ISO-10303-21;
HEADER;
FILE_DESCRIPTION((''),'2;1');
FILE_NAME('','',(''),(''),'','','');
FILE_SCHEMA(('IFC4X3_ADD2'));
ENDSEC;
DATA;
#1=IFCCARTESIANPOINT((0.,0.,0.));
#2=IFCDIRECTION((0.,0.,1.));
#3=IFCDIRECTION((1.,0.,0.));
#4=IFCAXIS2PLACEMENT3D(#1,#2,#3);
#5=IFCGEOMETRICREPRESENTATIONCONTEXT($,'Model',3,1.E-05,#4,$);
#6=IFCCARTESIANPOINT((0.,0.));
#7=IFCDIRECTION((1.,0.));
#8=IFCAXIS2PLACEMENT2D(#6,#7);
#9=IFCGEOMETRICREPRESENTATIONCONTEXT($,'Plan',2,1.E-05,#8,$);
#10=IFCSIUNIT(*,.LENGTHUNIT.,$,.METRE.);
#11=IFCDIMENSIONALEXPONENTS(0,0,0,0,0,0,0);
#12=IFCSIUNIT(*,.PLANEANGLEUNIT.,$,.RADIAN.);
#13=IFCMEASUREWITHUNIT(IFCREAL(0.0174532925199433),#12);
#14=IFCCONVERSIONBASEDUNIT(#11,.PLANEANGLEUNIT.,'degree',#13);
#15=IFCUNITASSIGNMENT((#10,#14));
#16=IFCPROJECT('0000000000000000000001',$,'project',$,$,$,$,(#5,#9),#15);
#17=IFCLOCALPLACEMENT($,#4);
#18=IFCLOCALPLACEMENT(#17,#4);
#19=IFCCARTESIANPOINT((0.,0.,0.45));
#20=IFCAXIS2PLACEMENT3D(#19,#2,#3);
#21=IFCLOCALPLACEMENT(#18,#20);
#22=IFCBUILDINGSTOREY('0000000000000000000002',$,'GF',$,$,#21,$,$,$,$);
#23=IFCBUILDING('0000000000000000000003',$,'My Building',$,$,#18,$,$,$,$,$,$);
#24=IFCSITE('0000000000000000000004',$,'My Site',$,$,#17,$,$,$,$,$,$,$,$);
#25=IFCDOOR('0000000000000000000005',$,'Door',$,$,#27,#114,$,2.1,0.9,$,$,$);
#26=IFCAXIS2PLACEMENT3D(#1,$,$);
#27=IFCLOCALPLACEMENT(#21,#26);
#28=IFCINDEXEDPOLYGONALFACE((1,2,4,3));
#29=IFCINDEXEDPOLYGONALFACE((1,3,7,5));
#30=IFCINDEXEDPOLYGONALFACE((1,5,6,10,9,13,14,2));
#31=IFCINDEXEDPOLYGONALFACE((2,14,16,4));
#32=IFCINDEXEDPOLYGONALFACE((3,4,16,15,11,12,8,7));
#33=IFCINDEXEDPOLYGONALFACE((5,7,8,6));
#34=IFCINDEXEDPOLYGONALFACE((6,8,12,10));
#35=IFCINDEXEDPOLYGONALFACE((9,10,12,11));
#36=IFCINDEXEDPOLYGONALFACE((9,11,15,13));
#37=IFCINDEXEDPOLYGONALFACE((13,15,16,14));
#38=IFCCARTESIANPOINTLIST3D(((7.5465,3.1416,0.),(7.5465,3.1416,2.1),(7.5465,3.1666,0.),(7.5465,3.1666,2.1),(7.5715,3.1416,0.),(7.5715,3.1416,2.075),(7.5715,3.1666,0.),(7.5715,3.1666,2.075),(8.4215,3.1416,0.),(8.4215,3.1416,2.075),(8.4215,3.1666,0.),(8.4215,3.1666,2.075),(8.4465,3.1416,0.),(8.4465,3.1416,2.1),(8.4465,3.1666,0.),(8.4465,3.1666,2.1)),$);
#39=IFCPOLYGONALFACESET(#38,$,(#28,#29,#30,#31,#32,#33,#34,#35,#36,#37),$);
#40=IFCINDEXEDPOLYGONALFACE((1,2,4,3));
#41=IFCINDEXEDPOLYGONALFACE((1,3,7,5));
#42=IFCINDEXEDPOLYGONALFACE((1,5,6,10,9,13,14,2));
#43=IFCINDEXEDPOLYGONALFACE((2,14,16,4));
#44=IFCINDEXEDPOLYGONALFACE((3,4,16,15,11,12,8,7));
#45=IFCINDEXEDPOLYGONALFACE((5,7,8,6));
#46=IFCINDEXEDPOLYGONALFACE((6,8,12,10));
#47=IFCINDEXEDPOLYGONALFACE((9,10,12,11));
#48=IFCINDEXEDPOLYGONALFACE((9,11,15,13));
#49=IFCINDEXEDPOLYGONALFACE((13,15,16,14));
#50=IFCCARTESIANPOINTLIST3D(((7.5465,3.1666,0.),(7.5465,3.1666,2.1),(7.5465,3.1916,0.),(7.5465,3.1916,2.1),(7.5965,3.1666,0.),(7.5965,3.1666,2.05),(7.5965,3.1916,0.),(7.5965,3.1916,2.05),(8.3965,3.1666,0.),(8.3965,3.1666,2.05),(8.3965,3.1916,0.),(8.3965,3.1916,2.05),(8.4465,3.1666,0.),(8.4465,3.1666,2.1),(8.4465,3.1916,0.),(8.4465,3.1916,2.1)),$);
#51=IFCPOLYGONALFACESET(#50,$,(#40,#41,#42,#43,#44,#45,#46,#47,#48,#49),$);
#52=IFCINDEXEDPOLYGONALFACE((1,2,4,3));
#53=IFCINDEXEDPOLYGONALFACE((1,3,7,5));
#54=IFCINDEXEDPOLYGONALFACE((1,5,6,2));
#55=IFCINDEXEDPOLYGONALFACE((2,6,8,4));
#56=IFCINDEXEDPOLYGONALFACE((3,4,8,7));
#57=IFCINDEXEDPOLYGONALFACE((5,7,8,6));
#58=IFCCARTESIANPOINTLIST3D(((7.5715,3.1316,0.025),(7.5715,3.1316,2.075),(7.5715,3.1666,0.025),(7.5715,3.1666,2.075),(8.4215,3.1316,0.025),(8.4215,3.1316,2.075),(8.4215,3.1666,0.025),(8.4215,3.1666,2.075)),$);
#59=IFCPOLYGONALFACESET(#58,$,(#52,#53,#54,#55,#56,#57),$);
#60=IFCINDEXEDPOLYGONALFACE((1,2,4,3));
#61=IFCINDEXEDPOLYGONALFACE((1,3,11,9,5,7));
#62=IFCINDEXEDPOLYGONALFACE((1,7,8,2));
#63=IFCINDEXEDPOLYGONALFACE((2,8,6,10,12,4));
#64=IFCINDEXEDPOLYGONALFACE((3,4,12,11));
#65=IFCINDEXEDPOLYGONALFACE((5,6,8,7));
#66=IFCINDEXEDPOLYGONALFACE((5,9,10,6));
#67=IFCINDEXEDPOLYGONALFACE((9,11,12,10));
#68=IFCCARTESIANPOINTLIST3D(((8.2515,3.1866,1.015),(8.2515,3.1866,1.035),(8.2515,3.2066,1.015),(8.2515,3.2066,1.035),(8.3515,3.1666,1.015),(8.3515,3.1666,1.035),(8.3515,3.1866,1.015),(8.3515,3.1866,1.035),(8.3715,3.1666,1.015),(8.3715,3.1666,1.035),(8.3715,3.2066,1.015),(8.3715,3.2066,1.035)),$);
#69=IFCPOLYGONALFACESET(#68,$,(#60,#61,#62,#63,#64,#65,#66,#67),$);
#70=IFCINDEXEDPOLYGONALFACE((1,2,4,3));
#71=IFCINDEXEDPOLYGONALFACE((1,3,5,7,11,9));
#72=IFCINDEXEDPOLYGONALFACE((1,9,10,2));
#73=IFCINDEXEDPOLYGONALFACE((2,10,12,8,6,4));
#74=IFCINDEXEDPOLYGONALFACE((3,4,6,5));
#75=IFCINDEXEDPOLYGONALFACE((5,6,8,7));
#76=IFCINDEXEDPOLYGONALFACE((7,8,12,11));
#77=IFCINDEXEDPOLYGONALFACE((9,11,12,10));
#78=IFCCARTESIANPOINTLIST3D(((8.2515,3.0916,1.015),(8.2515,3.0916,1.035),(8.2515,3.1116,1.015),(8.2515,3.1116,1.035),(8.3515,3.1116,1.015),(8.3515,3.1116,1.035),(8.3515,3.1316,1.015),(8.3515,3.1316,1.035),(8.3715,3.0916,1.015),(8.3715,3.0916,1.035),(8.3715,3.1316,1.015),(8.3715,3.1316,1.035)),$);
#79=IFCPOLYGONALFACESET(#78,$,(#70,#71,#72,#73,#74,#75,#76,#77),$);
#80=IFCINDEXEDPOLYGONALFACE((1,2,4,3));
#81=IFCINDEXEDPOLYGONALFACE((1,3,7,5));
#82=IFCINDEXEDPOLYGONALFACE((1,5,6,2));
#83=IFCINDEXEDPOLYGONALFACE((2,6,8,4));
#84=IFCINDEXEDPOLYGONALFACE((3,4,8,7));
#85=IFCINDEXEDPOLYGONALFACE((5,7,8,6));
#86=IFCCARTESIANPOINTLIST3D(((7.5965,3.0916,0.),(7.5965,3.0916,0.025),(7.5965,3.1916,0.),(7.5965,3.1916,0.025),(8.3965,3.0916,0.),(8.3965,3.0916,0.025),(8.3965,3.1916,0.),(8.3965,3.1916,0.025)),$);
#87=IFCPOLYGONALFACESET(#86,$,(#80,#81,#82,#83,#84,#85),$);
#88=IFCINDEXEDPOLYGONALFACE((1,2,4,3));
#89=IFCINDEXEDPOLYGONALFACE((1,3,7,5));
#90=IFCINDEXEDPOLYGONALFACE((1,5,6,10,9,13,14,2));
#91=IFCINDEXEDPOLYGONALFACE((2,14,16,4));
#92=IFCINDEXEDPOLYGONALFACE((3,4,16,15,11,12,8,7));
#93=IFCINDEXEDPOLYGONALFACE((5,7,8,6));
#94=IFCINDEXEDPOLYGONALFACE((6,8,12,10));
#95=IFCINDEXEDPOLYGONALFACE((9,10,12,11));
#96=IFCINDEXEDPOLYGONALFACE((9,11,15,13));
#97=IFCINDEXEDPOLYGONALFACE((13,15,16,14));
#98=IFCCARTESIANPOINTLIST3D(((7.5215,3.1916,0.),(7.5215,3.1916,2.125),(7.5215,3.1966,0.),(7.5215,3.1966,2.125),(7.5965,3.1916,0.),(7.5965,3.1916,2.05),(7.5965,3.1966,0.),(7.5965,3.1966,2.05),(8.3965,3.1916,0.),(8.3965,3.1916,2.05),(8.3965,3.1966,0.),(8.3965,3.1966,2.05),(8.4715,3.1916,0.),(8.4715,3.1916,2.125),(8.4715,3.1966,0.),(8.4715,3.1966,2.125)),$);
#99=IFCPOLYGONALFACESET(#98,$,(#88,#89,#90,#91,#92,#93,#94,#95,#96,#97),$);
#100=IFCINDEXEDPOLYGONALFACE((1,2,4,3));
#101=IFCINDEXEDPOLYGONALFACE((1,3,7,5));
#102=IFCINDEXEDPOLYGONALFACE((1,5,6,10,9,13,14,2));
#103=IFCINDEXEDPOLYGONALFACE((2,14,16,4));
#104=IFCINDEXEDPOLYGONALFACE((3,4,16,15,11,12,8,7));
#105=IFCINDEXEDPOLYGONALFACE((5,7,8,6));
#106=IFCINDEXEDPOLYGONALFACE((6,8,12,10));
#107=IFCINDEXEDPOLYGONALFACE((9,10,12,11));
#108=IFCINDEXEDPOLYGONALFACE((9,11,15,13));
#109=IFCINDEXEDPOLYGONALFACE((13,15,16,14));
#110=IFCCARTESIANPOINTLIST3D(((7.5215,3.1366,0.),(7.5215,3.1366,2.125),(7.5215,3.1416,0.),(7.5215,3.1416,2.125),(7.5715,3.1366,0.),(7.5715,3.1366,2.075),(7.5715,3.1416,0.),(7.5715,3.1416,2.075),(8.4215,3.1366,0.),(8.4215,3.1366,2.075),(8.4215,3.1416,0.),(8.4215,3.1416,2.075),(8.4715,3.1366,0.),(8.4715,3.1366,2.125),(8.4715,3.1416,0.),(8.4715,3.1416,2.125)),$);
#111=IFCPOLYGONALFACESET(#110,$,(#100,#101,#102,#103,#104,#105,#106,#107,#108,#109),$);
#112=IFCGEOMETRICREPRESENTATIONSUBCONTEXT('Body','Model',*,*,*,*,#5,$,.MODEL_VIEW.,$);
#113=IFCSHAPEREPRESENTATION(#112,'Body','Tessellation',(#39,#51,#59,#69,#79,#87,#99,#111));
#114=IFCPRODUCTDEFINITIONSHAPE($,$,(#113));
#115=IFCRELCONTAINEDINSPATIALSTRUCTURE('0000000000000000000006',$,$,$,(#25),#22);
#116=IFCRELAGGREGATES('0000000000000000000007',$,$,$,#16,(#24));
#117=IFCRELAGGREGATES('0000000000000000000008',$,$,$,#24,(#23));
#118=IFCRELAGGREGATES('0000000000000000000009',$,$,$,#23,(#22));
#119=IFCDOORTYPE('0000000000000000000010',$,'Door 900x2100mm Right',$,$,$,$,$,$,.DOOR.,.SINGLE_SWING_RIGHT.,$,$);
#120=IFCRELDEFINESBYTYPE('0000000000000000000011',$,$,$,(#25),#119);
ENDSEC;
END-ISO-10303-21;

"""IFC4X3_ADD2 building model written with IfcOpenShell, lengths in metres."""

from ifc_helpers import new_model, entity, si_unit, converted_unit, frame, origin_with_axes, origin_2d_with_axis, place, context, subcontext, project, spatial, line, indexed_curve, outline, extrude, shape, source, transform, mapped, type_object, type_shapes, element, save


model = new_model("IFC4X3_ADD2")

# Units and contexts
model_context = context("Model", 3, precision=1e-05, world=origin_with_axes())
plan_context = context("Plan", 2, precision=1e-05, world=origin_2d_with_axis())
body_context_1 = subcontext(model_context, "Body", "Model", "MODEL_VIEW")
body_context_2 = subcontext(plan_context, "Body", "Plan", "PLAN_VIEW")
ifc_project = project(units=[si_unit("LENGTHUNIT", "METRE"), converted_unit("PLANEANGLEUNIT", "degree", entity("IfcReal", 0.0174532925199433), si_unit("PLANEANGLEUNIT", "RADIAN"), dimensions=[0, 0, 0, 0, 0, 0, 0])], contexts=[model_context, plan_context])

# Site, building, storey
site_placement = place(None, origin_with_axes())
site = spatial("IfcSite", under=ifc_project, at=site_placement, Name="My Site")
building_placement = place(site_placement, origin_with_axes())
building = spatial("IfcBuilding", under=site, at=building_placement, Name="My Building")
storey_placement = place(building_placement, frame((0.0, 0.0, 0.45), z_axis=(0.0, 0.0, 1.0), x_axis=(1.0, 0.0, 0.0)))
storey = spatial("IfcBuildingStorey", under=building, at=storey_placement, Name="GF")

# Shared definitions
door_type_1 = type_object("IfcDoorType", Name="Door 900x2100mm Right", OperationType="SINGLE_SWING_RIGHT", PredefinedType="DOOR")
shared_shape_1 = source(origin_with_axes(), body_context_1, "Body", "SweptSolid", [
    extrude(outline(indexed_curve([(0.0, 0.0), (0.0, 2.1), (0.9, 2.1), (0.9, 0.0), (0.875, 0.0), (0.875, 2.075), (0.025, 2.075), (0.025, 0.0)], segments=[line(1, 2, 3, 4, 5, 6, 7, 8, 1)])), frame((0.0, 0.025, 0.0), z_axis=(0.0, -1.0, 0.0), x_axis=(1.0, 0.0, 0.0)), (0.0, 0.0, -1.0), 0.025),
    extrude(outline(indexed_curve([(0.0, 0.0), (0.0, 2.1), (0.9, 2.1), (0.9, 0.0), (0.85, 0.0), (0.85, 2.05), (0.05, 2.05), (0.05, 0.0)], segments=[line(1, 2, 3, 4, 5, 6, 7, 8, 1)])), frame((0.0, 0.0, 0.0), z_axis=(0.0, -1.0, 0.0), x_axis=(1.0, 0.0, 0.0)), (0.0, 0.0, -1.0), 0.025),
    extrude(outline(indexed_curve([(0.0, 0.0), (0.85, 0.0), (0.85, 0.035), (0.0, 0.035)], segments=[line(1, 2, 3, 4, 1)])), frame((0.025, 0.025, 0.025), z_axis=(0.0, 0.0, 1.0), x_axis=(1.0, 0.0, 0.0)), (0.0, 0.0, 1.0), 2.05),
    extrude(outline(indexed_curve([(0.0, 0.0), (0.0, -0.04), (0.12, -0.04), (0.12, -0.02), (0.02, -0.02), (0.02, 0.0)], segments=[line(1, 2, 3, 4, 5, 6, 1)])), frame((0.075, 0.025, 1.015), z_axis=(0.0, 0.0, 1.0), x_axis=(1.0, 0.0, 0.0)), (0.0, 0.0, 1.0), 0.02),
    extrude(outline(indexed_curve([(0.0, 0.0), (0.0, 0.04), (0.12, 0.04), (0.12, 0.02), (0.02, 0.02), (0.02, 0.0)], segments=[line(1, 2, 3, 4, 5, 6, 1)])), frame((0.075, 0.06, 1.015), z_axis=(0.0, 0.0, 1.0), x_axis=(1.0, 0.0, 0.0)), (0.0, 0.0, 1.0), 0.02),
    extrude(outline(indexed_curve([(0.0, 0.0), (0.8, 0.0), (0.8, 0.1), (0.0, 0.1)], segments=[line(1, 2, 3, 4, 1)])), frame((0.05, 0.0, 0.0), z_axis=(0.0, 0.0, 1.0), x_axis=(1.0, 0.0, 0.0)), (0.0, 0.0, 1.0), 0.025),
    extrude(outline(indexed_curve([(0.0, 0.0), (0.0, 2.125), (0.95, 2.125), (0.95, 0.0), (0.875, 0.0), (0.875, 2.05), (0.075, 2.05), (0.075, 0.0)], segments=[line(1, 2, 3, 4, 5, 6, 7, 8, 1)])), frame((-0.025, -0.005, 0.0), z_axis=(0.0, -1.0, 0.0), x_axis=(1.0, 0.0, 0.0)), (0.0, 0.0, -1.0), 0.005),
    extrude(outline(indexed_curve([(0.0, 0.0), (0.0, 2.125), (0.95, 2.125), (0.95, 0.0), (0.9, 0.0), (0.9, 2.075), (0.05, 2.075), (0.05, 0.0)], segments=[line(1, 2, 3, 4, 5, 6, 7, 8, 1)])), frame((-0.025, 0.05, 0.0), z_axis=(0.0, -1.0, 0.0), x_axis=(1.0, 0.0, 0.0)), (0.0, 0.0, -1.0), 0.005),
])
shared_shape_2 = source(origin_with_axes(), body_context_2, "Body", "Curve2D", [
    entity("IfcIndexedPolyCurve", entity("IfcCartesianPointList2D", [[0.0, 0.0], [0.0, 0.05], [0.025, 0.05], [0.025, 0.025], [0.05, 0.025], [0.05, 0.0]]), [entity("IfcLineIndex", [1, 2, 3, 4, 5, 6, 1])]),
    entity("IfcIndexedPolyCurve", entity("IfcCartesianPointList2D", [[0.9, 0.0], [0.9, 0.05], [0.875, 0.05], [0.875, 0.025], [0.85, 0.025], [0.85, 0.0]]), [entity("IfcLineIndex", [1, 2, 3, 4, 5, 6, 1])]),
    entity("IfcTrimmedCurve", entity("IfcEllipse", entity("IfcAxis2Placement2D", entity("IfcCartesianPoint", [0.84, 0.05]), entity("IfcDirection", [1.0, 0.0])), 0.815, 0.85), [entity("IfcCartesianPoint", [0.84, 0.9])], [entity("IfcCartesianPoint", [0.025, 0.05])], True, "CARTESIAN"),
    entity("IfcIndexedPolyCurve", entity("IfcCartesianPointList2D", [[0.875, 0.05], [0.84, 0.05], [0.84, 0.9], [0.875, 0.9]]), [entity("IfcLineIndex", [1, 2, 3, 4, 1])]),
])
type_shapes(door_type_1, [shared_shape_1, shared_shape_2])

# Door
door_1_placement = place(storey_placement, frame((8.4465, 3.1916, 0.0), z_axis=(0.0, 0.0, 1.0), x_axis=(-1.0, 0.000001, 0.0)))
element("IfcDoor", 1, at=door_1_placement, inside=storey, type_object=door_type_1, Name="Door", OverallHeight=2.1, OverallWidth=0.9, shapes=[
    shape(body_context_1, "Body", "MappedRepresentation", [mapped(shared_shape_1, transform((0.0, 0.0, 0.0), x_axis=(1.0, 0.0, 0.0), y_axis=(0.0, 1.0, 0.0), z_axis=(0.0, 0.0, 1.0), scale=1.0))]),
    shape(body_context_2, "Body", "MappedRepresentation", [mapped(shared_shape_2, transform((0.0, 0.0, 0.0), x_axis=(1.0, 0.0, 0.0), y_axis=(0.0, 1.0, 0.0), z_axis=(0.0, 0.0, 1.0), scale=1.0))]),
])

save(model, "model.ifc")
